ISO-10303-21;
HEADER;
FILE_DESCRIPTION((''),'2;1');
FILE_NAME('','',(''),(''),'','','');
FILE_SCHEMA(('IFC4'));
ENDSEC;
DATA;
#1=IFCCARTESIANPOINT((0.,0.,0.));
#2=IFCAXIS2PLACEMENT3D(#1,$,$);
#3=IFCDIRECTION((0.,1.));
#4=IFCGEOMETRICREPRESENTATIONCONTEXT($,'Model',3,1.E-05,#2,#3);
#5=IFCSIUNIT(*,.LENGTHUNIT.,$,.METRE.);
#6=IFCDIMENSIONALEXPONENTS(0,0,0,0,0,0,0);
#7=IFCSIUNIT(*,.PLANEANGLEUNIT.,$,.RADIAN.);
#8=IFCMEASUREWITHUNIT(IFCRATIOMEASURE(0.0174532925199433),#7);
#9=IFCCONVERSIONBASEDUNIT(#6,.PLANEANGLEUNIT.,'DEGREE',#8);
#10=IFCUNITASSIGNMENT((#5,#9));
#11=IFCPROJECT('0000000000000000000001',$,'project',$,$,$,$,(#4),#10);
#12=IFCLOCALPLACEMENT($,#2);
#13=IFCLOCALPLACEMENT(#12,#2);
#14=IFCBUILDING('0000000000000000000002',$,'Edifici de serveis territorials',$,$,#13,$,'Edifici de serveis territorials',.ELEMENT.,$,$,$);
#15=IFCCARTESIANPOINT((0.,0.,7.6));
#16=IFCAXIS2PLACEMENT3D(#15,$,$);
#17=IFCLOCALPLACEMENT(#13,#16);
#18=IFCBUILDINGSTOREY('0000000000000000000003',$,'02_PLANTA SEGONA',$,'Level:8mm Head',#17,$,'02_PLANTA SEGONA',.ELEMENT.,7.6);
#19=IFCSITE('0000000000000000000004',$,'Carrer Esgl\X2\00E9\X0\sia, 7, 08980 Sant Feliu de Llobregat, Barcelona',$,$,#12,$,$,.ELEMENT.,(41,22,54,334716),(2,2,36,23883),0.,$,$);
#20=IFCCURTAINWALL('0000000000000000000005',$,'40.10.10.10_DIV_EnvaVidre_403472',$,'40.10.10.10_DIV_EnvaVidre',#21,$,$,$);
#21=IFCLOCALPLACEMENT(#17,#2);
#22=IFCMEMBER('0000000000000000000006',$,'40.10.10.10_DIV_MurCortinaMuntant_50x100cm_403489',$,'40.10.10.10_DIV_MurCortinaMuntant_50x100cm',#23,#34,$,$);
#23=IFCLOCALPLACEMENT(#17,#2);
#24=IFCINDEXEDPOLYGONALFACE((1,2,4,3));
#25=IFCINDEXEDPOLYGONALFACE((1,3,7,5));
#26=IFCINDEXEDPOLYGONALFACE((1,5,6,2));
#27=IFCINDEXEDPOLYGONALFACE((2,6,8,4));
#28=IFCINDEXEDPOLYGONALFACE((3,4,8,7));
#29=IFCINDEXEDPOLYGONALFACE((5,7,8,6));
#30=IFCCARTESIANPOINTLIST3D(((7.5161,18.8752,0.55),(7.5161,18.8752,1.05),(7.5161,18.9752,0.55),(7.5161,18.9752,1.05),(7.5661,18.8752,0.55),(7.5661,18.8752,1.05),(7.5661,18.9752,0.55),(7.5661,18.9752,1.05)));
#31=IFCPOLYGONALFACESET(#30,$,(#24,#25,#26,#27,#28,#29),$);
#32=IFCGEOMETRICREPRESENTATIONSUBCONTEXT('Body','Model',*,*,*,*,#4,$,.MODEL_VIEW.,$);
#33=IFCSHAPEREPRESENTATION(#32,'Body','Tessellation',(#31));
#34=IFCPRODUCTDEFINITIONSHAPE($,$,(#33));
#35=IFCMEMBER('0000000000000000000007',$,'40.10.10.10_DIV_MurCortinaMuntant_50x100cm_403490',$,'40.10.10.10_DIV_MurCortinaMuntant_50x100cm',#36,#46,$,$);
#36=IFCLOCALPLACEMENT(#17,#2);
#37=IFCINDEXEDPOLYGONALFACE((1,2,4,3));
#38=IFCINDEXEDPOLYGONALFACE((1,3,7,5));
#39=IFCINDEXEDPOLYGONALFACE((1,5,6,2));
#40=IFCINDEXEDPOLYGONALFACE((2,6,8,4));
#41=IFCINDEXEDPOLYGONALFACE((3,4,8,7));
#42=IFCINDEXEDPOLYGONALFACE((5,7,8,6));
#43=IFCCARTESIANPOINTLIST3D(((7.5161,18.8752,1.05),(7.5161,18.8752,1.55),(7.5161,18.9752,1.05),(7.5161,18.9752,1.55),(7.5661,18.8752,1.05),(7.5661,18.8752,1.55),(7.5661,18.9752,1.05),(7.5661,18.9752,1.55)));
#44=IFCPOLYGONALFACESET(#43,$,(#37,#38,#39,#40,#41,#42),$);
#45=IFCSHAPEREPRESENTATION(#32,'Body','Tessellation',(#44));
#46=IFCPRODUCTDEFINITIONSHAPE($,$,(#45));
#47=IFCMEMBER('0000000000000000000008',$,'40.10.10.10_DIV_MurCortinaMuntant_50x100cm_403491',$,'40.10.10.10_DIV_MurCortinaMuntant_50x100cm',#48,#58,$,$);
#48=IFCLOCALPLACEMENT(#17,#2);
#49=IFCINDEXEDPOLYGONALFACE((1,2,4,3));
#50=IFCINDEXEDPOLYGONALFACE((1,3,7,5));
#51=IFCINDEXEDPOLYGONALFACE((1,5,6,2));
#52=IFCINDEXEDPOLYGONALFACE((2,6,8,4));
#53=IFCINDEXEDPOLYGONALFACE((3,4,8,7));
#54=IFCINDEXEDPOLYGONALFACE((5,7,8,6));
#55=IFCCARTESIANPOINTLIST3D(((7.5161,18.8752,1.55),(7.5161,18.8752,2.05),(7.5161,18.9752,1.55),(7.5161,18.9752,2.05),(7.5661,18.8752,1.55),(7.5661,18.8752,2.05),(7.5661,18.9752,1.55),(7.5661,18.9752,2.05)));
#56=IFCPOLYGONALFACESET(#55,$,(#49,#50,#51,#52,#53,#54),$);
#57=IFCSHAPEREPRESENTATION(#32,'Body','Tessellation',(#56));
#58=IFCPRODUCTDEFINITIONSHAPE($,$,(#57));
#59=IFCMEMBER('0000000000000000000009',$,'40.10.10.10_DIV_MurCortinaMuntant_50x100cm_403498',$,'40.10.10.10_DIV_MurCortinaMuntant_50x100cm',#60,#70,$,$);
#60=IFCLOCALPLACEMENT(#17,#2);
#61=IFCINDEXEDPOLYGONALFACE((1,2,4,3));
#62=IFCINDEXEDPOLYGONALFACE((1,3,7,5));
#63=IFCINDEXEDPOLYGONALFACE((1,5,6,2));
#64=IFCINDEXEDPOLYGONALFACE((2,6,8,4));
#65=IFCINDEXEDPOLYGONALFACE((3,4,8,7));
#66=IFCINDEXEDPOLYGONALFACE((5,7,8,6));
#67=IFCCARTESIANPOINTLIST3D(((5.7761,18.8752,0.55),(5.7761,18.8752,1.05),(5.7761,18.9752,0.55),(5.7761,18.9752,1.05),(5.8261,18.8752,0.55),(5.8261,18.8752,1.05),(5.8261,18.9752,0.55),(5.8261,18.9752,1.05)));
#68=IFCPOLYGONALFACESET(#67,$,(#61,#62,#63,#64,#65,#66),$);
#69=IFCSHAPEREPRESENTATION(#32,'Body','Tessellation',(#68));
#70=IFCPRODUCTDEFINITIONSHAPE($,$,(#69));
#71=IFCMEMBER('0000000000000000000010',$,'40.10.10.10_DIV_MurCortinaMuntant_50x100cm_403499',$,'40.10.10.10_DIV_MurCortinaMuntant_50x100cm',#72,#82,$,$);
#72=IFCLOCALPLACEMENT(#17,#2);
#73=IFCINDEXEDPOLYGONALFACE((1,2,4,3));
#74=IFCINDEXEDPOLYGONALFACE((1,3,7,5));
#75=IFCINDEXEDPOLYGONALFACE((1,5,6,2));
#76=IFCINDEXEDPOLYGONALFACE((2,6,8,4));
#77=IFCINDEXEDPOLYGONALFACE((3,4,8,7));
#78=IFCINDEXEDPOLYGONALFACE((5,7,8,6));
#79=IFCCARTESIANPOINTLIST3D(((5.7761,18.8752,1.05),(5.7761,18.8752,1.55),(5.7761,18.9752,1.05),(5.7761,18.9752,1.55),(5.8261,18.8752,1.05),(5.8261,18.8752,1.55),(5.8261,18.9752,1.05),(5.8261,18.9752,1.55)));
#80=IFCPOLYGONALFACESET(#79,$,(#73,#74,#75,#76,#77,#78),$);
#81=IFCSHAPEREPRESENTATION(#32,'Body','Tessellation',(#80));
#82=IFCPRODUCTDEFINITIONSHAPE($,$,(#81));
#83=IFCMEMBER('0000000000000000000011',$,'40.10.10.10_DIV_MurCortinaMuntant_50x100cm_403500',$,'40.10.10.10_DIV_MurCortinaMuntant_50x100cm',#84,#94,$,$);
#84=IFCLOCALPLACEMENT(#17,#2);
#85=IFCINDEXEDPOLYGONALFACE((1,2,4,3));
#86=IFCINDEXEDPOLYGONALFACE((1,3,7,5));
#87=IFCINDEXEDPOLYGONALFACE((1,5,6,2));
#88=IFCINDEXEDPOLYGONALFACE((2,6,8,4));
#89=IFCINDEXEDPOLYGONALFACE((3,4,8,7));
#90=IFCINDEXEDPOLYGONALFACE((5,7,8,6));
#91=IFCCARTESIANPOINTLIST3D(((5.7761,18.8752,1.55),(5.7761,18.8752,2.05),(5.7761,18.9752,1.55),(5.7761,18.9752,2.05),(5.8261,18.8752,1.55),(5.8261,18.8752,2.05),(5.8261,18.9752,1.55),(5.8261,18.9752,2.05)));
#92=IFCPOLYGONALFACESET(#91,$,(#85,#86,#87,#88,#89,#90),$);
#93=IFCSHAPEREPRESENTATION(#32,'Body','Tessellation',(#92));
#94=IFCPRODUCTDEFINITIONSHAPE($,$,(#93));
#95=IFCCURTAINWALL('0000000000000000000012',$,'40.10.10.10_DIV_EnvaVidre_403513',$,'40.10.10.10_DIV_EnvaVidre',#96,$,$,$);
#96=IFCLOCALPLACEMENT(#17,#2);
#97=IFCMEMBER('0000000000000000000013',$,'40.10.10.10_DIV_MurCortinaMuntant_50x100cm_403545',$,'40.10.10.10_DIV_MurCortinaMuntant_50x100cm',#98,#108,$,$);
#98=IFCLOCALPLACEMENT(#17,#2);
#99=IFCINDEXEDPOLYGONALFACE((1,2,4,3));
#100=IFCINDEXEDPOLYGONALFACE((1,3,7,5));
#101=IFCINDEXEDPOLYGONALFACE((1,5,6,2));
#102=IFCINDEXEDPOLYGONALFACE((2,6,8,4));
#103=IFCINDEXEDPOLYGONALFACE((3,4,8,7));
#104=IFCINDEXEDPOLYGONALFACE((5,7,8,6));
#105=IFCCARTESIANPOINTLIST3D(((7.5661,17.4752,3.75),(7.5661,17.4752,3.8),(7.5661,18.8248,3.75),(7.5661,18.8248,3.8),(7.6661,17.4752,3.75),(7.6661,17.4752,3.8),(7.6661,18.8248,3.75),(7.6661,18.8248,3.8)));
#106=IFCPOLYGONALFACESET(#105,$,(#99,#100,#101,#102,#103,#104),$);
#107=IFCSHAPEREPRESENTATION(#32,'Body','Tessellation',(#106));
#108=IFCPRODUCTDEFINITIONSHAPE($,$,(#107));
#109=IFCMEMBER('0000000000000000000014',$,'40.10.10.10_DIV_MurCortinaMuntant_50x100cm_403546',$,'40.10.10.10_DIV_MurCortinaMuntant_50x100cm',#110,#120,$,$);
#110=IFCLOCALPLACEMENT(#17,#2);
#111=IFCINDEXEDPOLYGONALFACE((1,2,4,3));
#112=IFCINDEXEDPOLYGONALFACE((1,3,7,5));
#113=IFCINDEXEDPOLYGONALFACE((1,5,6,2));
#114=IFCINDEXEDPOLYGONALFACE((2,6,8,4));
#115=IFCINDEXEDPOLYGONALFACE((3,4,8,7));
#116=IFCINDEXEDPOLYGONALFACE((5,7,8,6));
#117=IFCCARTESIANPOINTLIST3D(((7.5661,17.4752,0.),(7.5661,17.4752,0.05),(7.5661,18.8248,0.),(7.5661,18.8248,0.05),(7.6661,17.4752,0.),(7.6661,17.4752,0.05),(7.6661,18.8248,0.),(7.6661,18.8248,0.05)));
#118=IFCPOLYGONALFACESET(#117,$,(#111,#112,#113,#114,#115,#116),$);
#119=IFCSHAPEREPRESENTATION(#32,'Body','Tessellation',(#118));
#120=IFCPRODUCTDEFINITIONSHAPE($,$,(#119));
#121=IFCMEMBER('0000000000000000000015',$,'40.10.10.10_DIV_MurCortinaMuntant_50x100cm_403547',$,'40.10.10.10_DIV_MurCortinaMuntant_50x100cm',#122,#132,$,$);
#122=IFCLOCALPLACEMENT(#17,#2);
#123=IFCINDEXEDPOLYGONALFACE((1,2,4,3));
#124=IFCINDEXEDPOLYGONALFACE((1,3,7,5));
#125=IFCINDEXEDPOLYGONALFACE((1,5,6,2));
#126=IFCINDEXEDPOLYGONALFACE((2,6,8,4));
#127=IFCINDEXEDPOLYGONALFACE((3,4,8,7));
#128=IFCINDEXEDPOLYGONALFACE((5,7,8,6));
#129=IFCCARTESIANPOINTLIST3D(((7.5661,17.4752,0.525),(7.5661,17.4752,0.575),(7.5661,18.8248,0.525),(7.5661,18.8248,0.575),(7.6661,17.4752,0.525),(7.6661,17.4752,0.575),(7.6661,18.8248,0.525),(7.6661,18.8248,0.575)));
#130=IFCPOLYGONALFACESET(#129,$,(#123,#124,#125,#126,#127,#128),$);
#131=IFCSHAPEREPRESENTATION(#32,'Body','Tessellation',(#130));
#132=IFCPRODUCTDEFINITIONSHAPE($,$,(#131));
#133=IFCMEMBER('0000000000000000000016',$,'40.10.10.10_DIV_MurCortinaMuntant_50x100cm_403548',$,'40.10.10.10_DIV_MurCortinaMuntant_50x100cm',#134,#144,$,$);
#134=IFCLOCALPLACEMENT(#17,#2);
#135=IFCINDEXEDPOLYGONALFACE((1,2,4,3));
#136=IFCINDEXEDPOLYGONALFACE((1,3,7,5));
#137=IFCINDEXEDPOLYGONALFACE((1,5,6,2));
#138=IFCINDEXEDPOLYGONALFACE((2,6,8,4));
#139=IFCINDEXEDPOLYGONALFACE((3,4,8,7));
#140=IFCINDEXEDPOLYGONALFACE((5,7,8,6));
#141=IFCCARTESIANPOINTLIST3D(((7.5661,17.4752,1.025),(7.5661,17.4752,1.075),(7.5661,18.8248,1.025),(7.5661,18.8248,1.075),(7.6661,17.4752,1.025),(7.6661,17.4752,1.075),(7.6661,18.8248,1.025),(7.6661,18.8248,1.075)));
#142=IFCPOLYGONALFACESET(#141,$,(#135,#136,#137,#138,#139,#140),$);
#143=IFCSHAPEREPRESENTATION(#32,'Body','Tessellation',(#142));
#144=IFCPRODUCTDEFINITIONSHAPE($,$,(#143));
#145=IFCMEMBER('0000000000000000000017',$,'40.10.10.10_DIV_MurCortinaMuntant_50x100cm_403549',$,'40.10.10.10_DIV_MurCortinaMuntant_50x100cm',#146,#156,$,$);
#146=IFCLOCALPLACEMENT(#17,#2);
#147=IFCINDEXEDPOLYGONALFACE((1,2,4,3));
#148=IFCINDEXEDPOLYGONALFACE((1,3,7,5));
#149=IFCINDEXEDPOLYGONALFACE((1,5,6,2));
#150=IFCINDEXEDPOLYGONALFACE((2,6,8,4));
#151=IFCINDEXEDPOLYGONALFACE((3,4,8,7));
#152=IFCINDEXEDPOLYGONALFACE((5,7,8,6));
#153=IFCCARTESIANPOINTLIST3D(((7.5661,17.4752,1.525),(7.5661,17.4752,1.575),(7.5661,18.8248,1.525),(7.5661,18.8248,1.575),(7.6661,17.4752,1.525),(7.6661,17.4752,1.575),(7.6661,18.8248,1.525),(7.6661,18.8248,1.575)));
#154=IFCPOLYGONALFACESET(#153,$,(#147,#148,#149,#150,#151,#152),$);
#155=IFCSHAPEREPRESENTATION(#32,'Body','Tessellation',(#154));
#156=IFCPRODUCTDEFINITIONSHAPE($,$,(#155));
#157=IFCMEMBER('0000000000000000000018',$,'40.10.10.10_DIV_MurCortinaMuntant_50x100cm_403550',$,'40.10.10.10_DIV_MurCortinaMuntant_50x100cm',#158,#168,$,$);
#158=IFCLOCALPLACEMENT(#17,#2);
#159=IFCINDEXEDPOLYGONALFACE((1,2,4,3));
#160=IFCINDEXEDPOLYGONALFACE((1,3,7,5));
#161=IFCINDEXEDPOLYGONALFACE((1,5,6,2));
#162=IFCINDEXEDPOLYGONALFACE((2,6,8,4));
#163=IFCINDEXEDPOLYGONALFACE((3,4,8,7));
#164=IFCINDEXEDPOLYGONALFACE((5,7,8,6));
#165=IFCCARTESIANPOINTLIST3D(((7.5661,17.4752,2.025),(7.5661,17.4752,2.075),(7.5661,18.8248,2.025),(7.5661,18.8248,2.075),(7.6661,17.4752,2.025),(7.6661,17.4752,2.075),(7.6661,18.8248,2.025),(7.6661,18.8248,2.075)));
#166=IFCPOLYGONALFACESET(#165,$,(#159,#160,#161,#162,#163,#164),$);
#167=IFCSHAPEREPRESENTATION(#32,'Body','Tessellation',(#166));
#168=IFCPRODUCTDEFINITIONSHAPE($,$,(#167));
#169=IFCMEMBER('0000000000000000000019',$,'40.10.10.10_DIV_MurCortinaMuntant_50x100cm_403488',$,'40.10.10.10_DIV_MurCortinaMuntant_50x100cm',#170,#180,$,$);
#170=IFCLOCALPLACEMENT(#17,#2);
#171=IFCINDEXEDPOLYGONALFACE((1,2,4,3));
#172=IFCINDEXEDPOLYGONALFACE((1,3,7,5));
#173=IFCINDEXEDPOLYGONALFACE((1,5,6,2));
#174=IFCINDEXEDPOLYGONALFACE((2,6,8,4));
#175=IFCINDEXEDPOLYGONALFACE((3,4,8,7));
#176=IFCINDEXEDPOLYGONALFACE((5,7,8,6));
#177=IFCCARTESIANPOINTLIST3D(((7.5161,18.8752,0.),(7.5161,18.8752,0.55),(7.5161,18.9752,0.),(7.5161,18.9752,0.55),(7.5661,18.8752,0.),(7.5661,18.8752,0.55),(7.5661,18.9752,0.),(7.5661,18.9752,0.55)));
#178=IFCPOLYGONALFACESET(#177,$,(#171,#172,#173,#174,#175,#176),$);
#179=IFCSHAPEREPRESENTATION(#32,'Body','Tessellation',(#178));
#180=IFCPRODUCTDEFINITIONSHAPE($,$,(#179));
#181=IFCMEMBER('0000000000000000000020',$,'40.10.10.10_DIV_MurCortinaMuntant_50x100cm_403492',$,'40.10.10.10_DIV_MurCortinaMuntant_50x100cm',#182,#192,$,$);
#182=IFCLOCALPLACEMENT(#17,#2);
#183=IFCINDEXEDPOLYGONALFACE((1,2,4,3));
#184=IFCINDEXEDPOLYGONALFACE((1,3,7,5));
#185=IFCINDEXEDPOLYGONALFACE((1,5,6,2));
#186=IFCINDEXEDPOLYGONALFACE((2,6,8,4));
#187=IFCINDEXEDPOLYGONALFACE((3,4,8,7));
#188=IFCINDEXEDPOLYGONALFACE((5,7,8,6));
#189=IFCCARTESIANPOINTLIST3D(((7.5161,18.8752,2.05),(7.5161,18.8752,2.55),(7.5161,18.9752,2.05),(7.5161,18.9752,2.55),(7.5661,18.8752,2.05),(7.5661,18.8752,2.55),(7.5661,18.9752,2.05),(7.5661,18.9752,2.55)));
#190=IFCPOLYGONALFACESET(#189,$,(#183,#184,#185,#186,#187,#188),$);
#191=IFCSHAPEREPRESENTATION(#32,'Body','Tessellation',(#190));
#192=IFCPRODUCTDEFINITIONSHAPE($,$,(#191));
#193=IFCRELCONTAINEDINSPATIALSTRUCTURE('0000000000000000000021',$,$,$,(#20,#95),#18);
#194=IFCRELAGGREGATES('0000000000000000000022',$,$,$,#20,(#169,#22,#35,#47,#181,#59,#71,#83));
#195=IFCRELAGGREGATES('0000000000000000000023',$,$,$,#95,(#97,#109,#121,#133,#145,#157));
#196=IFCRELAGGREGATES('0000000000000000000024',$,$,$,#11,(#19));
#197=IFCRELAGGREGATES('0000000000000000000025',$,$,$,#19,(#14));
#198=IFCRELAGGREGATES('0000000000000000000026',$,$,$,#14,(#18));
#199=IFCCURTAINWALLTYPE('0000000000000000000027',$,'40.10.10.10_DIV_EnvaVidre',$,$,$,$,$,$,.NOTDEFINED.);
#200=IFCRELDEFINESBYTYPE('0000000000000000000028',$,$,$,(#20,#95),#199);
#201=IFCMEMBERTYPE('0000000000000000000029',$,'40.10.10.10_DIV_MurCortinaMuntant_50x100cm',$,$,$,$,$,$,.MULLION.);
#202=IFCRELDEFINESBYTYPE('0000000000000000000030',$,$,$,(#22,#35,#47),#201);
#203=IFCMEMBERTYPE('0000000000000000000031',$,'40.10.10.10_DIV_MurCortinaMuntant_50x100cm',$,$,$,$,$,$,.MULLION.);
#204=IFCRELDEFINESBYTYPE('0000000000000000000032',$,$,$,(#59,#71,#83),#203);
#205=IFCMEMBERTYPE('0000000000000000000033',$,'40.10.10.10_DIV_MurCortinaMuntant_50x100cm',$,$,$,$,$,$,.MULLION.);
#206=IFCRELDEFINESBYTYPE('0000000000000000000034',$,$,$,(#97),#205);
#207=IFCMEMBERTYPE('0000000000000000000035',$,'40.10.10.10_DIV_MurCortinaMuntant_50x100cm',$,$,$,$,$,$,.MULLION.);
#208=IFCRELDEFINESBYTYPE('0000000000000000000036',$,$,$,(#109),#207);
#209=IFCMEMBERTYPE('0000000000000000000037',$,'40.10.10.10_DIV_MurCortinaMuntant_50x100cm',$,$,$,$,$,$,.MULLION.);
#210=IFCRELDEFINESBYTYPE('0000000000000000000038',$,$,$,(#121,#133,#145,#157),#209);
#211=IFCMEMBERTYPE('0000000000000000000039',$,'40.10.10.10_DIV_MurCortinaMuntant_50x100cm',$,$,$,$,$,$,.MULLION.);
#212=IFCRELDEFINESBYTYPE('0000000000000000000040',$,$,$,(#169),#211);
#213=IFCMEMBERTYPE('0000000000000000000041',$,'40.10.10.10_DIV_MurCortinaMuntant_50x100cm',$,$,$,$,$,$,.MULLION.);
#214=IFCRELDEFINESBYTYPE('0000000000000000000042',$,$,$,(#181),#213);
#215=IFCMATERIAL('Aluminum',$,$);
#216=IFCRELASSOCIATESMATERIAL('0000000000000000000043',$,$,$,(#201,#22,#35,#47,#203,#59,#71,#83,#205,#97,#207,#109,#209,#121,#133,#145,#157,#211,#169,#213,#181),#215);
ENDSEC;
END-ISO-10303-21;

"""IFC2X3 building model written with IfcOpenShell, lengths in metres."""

from ifc_helpers import new_model, entity, si_unit, converted_unit, direction, frame, origin, origin_2d_with_axis, place, context, subcontext, project, spatial, rectangle, extrude, source, transform, mapped, material, type_object, type_shapes, element, aggregate, save


model = new_model("IFC2X3")

# Units and contexts
model_context = context("Model", 3, precision=1e-05, world=origin(), true_north=direction((0.0, 1.0)))
body_context = subcontext(model_context, "Body", "Model", "MODEL_VIEW")
ifc_project = project(units=[si_unit("LENGTHUNIT", "METRE"), converted_unit("PLANEANGLEUNIT", "DEGREE", entity("IfcRatioMeasure", 0.0174532925199433), si_unit("PLANEANGLEUNIT", "RADIAN"), dimensions=[0, 0, 0, 0, 0, 0, 0])], contexts=[model_context])

# Site, building, storey
site_placement = place(None, origin())
site = spatial("IfcSite", under=ifc_project, at=site_placement, Name="Carrer Església, 7, 08980 Sant Feliu de Llobregat, Barcelona", CompositionType="ELEMENT", RefLatitude=(41, 22, 54, 334716), RefLongitude=(2, 2, 36, 23883), RefElevation=0.0)
building_placement = place(site_placement, origin())
building = spatial("IfcBuilding", under=site, at=building_placement, Name="Edifici de serveis territorials", LongName="Edifici de serveis territorials", CompositionType="ELEMENT")
storey_placement = place(building_placement, frame((0.0, 0.0, 7.6)))
storey = spatial("IfcBuildingStorey", under=building, at=storey_placement, Name="02_PLANTA SEGONA", ObjectType="Level:8mm Head", LongName="02_PLANTA SEGONA", CompositionType="ELEMENT", Elevation=7.6)

# Curtain walls, members
curtain_wall_type = type_object("IfcCurtainWallType", Name="40.10.10.10_DIV_EnvaVidre", PredefinedType="NOTDEFINED")
curtain_wall_1_placement = place(storey_placement, frame((0.0, 0.0, -7.6)))
curtain_wall_1 = element("IfcCurtainWall", 1, at=curtain_wall_1_placement, inside=storey, type_object=curtain_wall_type, Name="40.10.10.10_DIV_EnvaVidre_403472", ObjectType="40.10.10.10_DIV_EnvaVidre")
ifc_material_1 = material(Name="Aluminum")
member_type_1 = type_object("IfcMemberType", Name="40.10.10.10_DIV_MurCortinaMuntant_50x100cm", PredefinedType="MULLION", material=ifc_material_1)
shared_shape_1 = source(origin(), body_context, "Body", "SweptSolid", [
    extrude(rectangle(XDim=0.1, YDim=0.05, at=origin_2d_with_axis()), frame((-0.025, 0.0, -0.5), z_axis=(0.0, 0.0, 1.0), x_axis=(0.0, -1.0, 0.0)), (0.0, 0.0, 1.0), 0.5),
])
type_shapes(member_type_1, [shared_shape_1])
member_1_placement = place(storey_placement, frame((7.5661, 18.9252, 0.55), z_axis=(0.0, 0.0, -1.0), x_axis=(1.0, 0.0, 0.0)))
member_1 = element("IfcMember", 2, at=member_1_placement, type_object=member_type_1, material=ifc_material_1, Name="40.10.10.10_DIV_MurCortinaMuntant_50x100cm_403489", ObjectType="40.10.10.10_DIV_MurCortinaMuntant_50x100cm", context=body_context, shape_type="MappedRepresentation", body=[
    mapped(shared_shape_1, transform((0.0, 0.0, 0.0), scale=1.0)),
])
member_2_placement = place(storey_placement, frame((7.5661, 18.9252, 1.05), z_axis=(0.0, 0.0, -1.0), x_axis=(1.0, 0.0, 0.0)))
member_2 = element("IfcMember", 3, at=member_2_placement, type_object=member_type_1, material=ifc_material_1, Name="40.10.10.10_DIV_MurCortinaMuntant_50x100cm_403490", ObjectType="40.10.10.10_DIV_MurCortinaMuntant_50x100cm", context=body_context, shape_type="MappedRepresentation", body=[
    mapped(shared_shape_1, transform((0.0, 0.0, 0.0), scale=1.0)),
])
member_3_placement = place(storey_placement, frame((7.5661, 18.9252, 1.55), z_axis=(0.0, 0.0, -1.0), x_axis=(1.0, 0.0, 0.0)))
member_3 = element("IfcMember", 4, at=member_3_placement, type_object=member_type_1, material=ifc_material_1, Name="40.10.10.10_DIV_MurCortinaMuntant_50x100cm_403491", ObjectType="40.10.10.10_DIV_MurCortinaMuntant_50x100cm", context=body_context, shape_type="MappedRepresentation", body=[
    mapped(shared_shape_1, transform((0.0, 0.0, 0.0), scale=1.0)),
])
member_type_2 = type_object("IfcMemberType", Name="40.10.10.10_DIV_MurCortinaMuntant_50x100cm", PredefinedType="MULLION", material=ifc_material_1)
shared_shape_2 = source(origin(), body_context, "Body", "SweptSolid", [
    extrude(rectangle(XDim=0.1, YDim=0.05, at=origin_2d_with_axis()), frame((-0.025, 0.0, -0.5), z_axis=(0.0, 0.0, 1.0), x_axis=(0.0, -1.0, 0.0)), (0.0, 0.0, 1.0), 0.5),
])
type_shapes(member_type_2, [shared_shape_2])
member_4_placement = place(storey_placement, frame((5.7761, 18.9252, 1.05), z_axis=(0.0, 0.0, 1.0), x_axis=(-1.0, 0.0, 0.0)))
member_4 = element("IfcMember", 5, at=member_4_placement, type_object=member_type_2, material=ifc_material_1, Name="40.10.10.10_DIV_MurCortinaMuntant_50x100cm_403498", ObjectType="40.10.10.10_DIV_MurCortinaMuntant_50x100cm", context=body_context, shape_type="MappedRepresentation", body=[
    mapped(shared_shape_2, transform((0.0, 0.0, 0.0), scale=1.0)),
])
member_5_placement = place(storey_placement, frame((5.7761, 18.9252, 1.55), z_axis=(0.0, 0.0, 1.0), x_axis=(-1.0, 0.0, 0.0)))
member_5 = element("IfcMember", 6, at=member_5_placement, type_object=member_type_2, material=ifc_material_1, Name="40.10.10.10_DIV_MurCortinaMuntant_50x100cm_403499", ObjectType="40.10.10.10_DIV_MurCortinaMuntant_50x100cm", context=body_context, shape_type="MappedRepresentation", body=[
    mapped(shared_shape_2, transform((0.0, 0.0, 0.0), scale=1.0)),
])
member_6_placement = place(storey_placement, frame((5.7761, 18.9252, 2.05), z_axis=(0.0, 0.0, 1.0), x_axis=(-1.0, 0.0, 0.0)))
member_6 = element("IfcMember", 7, at=member_6_placement, type_object=member_type_2, material=ifc_material_1, Name="40.10.10.10_DIV_MurCortinaMuntant_50x100cm_403500", ObjectType="40.10.10.10_DIV_MurCortinaMuntant_50x100cm", context=body_context, shape_type="MappedRepresentation", body=[
    mapped(shared_shape_2, transform((0.0, 0.0, 0.0), scale=1.0)),
])
curtain_wall_2_placement = place(storey_placement, frame((0.0, 0.0, -7.6)))
curtain_wall_2 = element("IfcCurtainWall", 8, at=curtain_wall_2_placement, inside=storey, type_object=curtain_wall_type, Name="40.10.10.10_DIV_EnvaVidre_403513", ObjectType="40.10.10.10_DIV_EnvaVidre")
member_type_3 = type_object("IfcMemberType", Name="40.10.10.10_DIV_MurCortinaMuntant_50x100cm", PredefinedType="MULLION", material=ifc_material_1)
shared_shape_3 = source(origin(), body_context, "Body", "SweptSolid", [
    extrude(rectangle(XDim=0.1, YDim=0.05, at=origin_2d_with_axis()), frame((-0.025, 0.0, -1.3496), z_axis=(0.0, 0.0, 1.0), x_axis=(0.0, -1.0, 0.0)), (0.0, 0.0, 1.0), 1.3496),
])
type_shapes(member_type_3, [shared_shape_3])
member_7_placement = place(storey_placement, frame((7.6161, 17.4752, 3.8), z_axis=(0.0, -1.0, 0.0), x_axis=(0.0, 0.0, 1.0)))
member_7 = element("IfcMember", 9, at=member_7_placement, type_object=member_type_3, material=ifc_material_1, Name="40.10.10.10_DIV_MurCortinaMuntant_50x100cm_403545", ObjectType="40.10.10.10_DIV_MurCortinaMuntant_50x100cm", context=body_context, shape_type="MappedRepresentation", body=[
    mapped(shared_shape_3, transform((0.0, 0.0, 0.0), scale=1.0)),
])
member_type_4 = type_object("IfcMemberType", Name="40.10.10.10_DIV_MurCortinaMuntant_50x100cm", PredefinedType="MULLION", material=ifc_material_1)
shared_shape_4 = source(origin(), body_context, "Body", "SweptSolid", [
    extrude(rectangle(XDim=0.1, YDim=0.05, at=origin_2d_with_axis()), frame((-0.025, 0.0, -1.3496), z_axis=(0.0, 0.0, 1.0), x_axis=(0.0, -1.0, 0.0)), (0.0, 0.0, 1.0), 1.3496),
])
type_shapes(member_type_4, [shared_shape_4])
member_8_placement = place(storey_placement, frame((7.6161, 18.8248, 0.0), z_axis=(0.0, 1.0, 0.0), x_axis=(0.0, 0.0, -1.0)))
member_8 = element("IfcMember", 10, at=member_8_placement, type_object=member_type_4, material=ifc_material_1, Name="40.10.10.10_DIV_MurCortinaMuntant_50x100cm_403546", ObjectType="40.10.10.10_DIV_MurCortinaMuntant_50x100cm", context=body_context, shape_type="MappedRepresentation", body=[
    mapped(shared_shape_4, transform((0.0, 0.0, 0.0), scale=1.0)),
])
member_type_5 = type_object("IfcMemberType", Name="40.10.10.10_DIV_MurCortinaMuntant_50x100cm", PredefinedType="MULLION", material=ifc_material_1)
shared_shape_5 = source(origin(), body_context, "Body", "SweptSolid", [
    extrude(rectangle(XDim=0.1, YDim=0.05, at=origin_2d_with_axis()), frame((0.0, 0.0, -1.3496), z_axis=(0.0, 0.0, 1.0), x_axis=(0.0, -1.0, 0.0)), (0.0, 0.0, 1.0), 1.3496),
])
type_shapes(member_type_5, [shared_shape_5])
member_9_placement = place(storey_placement, frame((7.6161, 17.4752, 0.55), z_axis=(0.0, -1.0, 0.0), x_axis=(0.0, 0.0, 1.0)))
member_9 = element("IfcMember", 11, at=member_9_placement, type_object=member_type_5, material=ifc_material_1, Name="40.10.10.10_DIV_MurCortinaMuntant_50x100cm_403547", ObjectType="40.10.10.10_DIV_MurCortinaMuntant_50x100cm", context=body_context, shape_type="MappedRepresentation", body=[
    mapped(shared_shape_5, transform((0.0, 0.0, 0.0), scale=1.0)),
])
member_10_placement = place(storey_placement, frame((7.6161, 17.4752, 1.05), z_axis=(0.0, -1.0, 0.0), x_axis=(0.0, 0.0, 1.0)))
member_10 = element("IfcMember", 12, at=member_10_placement, type_object=member_type_5, material=ifc_material_1, Name="40.10.10.10_DIV_MurCortinaMuntant_50x100cm_403548", ObjectType="40.10.10.10_DIV_MurCortinaMuntant_50x100cm", context=body_context, shape_type="MappedRepresentation", body=[
    mapped(shared_shape_5, transform((0.0, 0.0, 0.0), scale=1.0)),
])
member_11_placement = place(storey_placement, frame((7.6161, 17.4752, 1.55), z_axis=(0.0, -1.0, 0.0), x_axis=(0.0, 0.0, 1.0)))
member_11 = element("IfcMember", 13, at=member_11_placement, type_object=member_type_5, material=ifc_material_1, Name="40.10.10.10_DIV_MurCortinaMuntant_50x100cm_403549", ObjectType="40.10.10.10_DIV_MurCortinaMuntant_50x100cm", context=body_context, shape_type="MappedRepresentation", body=[
    mapped(shared_shape_5, transform((0.0, 0.0, 0.0), scale=1.0)),
])
member_12_placement = place(storey_placement, frame((7.6161, 17.4752, 2.05), z_axis=(0.0, -1.0, 0.0), x_axis=(0.0, 0.0, 1.0)))
member_12 = element("IfcMember", 14, at=member_12_placement, type_object=member_type_5, material=ifc_material_1, Name="40.10.10.10_DIV_MurCortinaMuntant_50x100cm_403550", ObjectType="40.10.10.10_DIV_MurCortinaMuntant_50x100cm", context=body_context, shape_type="MappedRepresentation", body=[
    mapped(shared_shape_5, transform((0.0, 0.0, 0.0), scale=1.0)),
])

# Members
member_type_6 = type_object("IfcMemberType", Name="40.10.10.10_DIV_MurCortinaMuntant_50x100cm", PredefinedType="MULLION", material=ifc_material_1)
shared_shape_6 = source(origin(), body_context, "Body", "SweptSolid", [
    extrude(rectangle(XDim=0.1, YDim=0.05, at=origin_2d_with_axis()), frame((-0.025, 0.0, -0.55), z_axis=(0.0, 0.0, 1.0), x_axis=(0.0, -1.0, 0.0)), (0.0, 0.0, 1.0), 0.55),
])
type_shapes(member_type_6, [shared_shape_6])
member_13_placement = place(storey_placement, frame((7.5661, 18.9252, 0.0), z_axis=(0.0, 0.0, -1.0), x_axis=(1.0, 0.0, 0.0)))
member_13 = element("IfcMember", 15, at=member_13_placement, type_object=member_type_6, material=ifc_material_1, Name="40.10.10.10_DIV_MurCortinaMuntant_50x100cm_403488", ObjectType="40.10.10.10_DIV_MurCortinaMuntant_50x100cm", context=body_context, shape_type="MappedRepresentation", body=[
    mapped(shared_shape_6, transform((0.0, 0.0, 0.0), scale=1.0)),
])
member_type_7 = type_object("IfcMemberType", Name="40.10.10.10_DIV_MurCortinaMuntant_50x100cm", PredefinedType="MULLION", material=ifc_material_1)
shared_shape_7 = source(origin(), body_context, "Body", "SweptSolid", [
    extrude(rectangle(XDim=0.1, YDim=0.05, at=origin_2d_with_axis()), frame((-0.025, 0.0, -0.5), z_axis=(0.0, 0.0, 1.0), x_axis=(0.0, -1.0, 0.0)), (0.0, 0.0, 1.0), 0.5),
])
type_shapes(member_type_7, [shared_shape_7])
member_14_placement = place(storey_placement, frame((7.5661, 18.9252, 2.05), z_axis=(0.0, 0.0, -1.0), x_axis=(1.0, 0.0, 0.0)))
member_14 = element("IfcMember", 16, at=member_14_placement, type_object=member_type_7, material=ifc_material_1, Name="40.10.10.10_DIV_MurCortinaMuntant_50x100cm_403492", ObjectType="40.10.10.10_DIV_MurCortinaMuntant_50x100cm", context=body_context, shape_type="MappedRepresentation", body=[
    mapped(shared_shape_7, transform((0.0, 0.0, 0.0), scale=1.0)),
])

aggregate(curtain_wall_1, [member_13, member_1, member_2, member_3, member_14, member_4, member_5, member_6])
aggregate(curtain_wall_2, [member_7, member_8, member_9, member_10, member_11, member_12])

save(model, "model.ifc")
